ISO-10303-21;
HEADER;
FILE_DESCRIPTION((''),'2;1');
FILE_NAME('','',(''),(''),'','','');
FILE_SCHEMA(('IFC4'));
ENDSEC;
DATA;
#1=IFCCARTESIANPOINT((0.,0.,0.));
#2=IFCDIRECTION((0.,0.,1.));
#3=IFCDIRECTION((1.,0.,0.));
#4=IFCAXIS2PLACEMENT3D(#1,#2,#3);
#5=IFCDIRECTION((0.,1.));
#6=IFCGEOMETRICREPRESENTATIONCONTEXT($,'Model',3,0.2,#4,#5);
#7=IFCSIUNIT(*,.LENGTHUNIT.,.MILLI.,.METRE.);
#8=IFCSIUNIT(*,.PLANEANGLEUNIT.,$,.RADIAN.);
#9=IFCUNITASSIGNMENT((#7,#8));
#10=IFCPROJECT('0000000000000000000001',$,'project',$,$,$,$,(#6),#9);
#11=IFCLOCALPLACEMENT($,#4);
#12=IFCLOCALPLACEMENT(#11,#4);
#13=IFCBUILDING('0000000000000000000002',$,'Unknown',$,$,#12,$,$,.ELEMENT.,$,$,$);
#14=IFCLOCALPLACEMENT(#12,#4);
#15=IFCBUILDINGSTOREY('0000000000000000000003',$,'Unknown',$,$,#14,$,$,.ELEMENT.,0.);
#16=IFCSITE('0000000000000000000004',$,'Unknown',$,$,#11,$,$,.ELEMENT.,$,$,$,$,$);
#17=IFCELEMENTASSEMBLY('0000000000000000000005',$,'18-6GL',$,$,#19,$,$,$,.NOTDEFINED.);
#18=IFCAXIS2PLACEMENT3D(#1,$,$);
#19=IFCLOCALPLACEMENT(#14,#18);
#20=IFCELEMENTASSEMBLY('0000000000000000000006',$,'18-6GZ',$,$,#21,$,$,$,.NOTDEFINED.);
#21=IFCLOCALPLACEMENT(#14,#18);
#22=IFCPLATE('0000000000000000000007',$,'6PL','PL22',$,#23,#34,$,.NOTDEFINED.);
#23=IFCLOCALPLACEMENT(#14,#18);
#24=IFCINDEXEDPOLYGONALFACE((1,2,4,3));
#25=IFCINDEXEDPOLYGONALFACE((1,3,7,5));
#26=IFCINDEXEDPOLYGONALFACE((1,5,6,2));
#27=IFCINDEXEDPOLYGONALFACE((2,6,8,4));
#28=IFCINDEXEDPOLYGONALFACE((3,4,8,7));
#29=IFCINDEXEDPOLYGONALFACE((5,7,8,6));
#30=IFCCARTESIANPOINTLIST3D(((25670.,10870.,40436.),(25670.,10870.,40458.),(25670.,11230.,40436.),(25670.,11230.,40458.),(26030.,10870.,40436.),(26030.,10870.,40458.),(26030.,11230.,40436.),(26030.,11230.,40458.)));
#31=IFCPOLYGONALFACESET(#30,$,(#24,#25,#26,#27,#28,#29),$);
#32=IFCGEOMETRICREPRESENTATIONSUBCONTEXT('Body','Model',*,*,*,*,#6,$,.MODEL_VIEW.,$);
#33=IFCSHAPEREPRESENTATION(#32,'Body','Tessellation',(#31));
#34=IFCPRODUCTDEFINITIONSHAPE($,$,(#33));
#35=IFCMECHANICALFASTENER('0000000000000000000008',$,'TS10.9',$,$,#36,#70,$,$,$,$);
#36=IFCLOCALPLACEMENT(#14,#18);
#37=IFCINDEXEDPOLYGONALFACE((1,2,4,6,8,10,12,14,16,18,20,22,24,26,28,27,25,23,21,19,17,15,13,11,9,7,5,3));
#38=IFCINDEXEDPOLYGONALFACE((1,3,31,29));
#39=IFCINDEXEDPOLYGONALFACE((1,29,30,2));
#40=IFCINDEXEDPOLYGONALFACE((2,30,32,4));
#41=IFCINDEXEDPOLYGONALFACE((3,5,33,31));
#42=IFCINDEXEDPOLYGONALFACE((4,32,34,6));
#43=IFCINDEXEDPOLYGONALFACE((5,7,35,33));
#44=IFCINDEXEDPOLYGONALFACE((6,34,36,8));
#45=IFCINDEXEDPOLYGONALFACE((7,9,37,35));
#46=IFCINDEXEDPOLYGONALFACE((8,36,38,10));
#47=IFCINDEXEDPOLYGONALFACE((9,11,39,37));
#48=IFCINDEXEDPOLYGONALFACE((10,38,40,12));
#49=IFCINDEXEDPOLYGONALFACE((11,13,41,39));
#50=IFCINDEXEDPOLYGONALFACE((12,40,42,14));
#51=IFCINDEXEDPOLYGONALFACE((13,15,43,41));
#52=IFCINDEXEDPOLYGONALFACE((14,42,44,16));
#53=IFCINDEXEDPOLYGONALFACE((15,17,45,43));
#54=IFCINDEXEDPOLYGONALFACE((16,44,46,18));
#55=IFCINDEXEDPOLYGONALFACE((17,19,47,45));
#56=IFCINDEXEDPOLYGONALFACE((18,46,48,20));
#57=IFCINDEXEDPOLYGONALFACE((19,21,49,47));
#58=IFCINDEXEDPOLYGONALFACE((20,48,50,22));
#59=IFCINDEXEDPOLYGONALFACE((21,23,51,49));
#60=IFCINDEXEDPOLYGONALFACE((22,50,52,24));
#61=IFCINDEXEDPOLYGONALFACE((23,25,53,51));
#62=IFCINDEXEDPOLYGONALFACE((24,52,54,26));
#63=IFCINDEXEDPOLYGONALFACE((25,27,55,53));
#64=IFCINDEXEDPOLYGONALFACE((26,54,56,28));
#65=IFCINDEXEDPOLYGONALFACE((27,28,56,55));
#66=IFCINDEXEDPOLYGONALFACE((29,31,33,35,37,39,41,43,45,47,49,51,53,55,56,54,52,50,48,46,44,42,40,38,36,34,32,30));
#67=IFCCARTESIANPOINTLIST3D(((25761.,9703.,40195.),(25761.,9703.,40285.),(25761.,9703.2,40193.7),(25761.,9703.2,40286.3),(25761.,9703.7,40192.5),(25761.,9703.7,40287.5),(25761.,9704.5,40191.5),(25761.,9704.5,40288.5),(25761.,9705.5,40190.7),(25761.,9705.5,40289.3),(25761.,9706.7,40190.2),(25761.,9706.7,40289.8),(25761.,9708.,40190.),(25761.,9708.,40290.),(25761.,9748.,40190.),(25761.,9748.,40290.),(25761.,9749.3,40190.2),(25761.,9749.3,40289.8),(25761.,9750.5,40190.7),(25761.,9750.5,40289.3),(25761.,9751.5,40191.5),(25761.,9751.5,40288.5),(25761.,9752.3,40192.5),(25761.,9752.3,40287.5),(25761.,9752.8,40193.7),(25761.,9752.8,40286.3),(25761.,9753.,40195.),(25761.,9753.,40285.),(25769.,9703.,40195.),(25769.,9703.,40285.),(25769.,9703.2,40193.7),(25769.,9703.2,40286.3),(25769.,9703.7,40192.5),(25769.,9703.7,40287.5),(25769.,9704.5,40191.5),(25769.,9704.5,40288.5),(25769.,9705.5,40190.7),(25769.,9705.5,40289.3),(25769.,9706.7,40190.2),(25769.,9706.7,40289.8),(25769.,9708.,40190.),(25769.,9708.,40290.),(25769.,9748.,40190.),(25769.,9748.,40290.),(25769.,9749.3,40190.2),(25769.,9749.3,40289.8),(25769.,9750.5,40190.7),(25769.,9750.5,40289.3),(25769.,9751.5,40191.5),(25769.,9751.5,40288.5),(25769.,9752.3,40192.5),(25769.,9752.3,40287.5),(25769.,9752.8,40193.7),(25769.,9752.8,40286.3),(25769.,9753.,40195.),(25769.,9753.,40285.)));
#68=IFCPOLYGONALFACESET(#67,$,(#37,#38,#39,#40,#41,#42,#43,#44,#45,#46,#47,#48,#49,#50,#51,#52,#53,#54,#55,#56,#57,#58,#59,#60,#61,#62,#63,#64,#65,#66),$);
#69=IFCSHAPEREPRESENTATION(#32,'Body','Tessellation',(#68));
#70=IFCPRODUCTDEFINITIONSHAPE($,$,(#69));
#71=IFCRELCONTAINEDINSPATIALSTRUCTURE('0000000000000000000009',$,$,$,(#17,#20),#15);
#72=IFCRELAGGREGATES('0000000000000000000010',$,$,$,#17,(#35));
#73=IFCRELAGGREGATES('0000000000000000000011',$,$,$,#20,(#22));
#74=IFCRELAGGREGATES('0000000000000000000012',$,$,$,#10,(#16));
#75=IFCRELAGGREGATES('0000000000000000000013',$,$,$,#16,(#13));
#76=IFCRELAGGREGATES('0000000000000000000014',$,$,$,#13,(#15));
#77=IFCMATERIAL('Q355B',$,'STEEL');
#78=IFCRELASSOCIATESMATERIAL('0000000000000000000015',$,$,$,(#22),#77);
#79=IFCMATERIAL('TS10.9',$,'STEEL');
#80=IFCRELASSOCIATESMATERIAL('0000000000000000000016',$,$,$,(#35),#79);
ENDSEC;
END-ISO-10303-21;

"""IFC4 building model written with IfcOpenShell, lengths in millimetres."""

from ifc_helpers import new_model, si_unit, direction, frame, origin_with_axes, place, context, subcontext, project, spatial, line, arc, indexed_curve, outline, extrude, source, transform, mapped, material, element, aggregate, save


model = new_model("IFC4")

# Units and contexts
model_context = context("Model", 3, precision=0.2, world=origin_with_axes(), true_north=direction((0.0, 1.0)))
body_context = subcontext(model_context, "Body", "Model", "MODEL_VIEW")
ifc_project = project(units=[si_unit("LENGTHUNIT", "METRE", prefix="MILLI"), si_unit("PLANEANGLEUNIT", "RADIAN")], contexts=[model_context])

# Site, building, storey
site_placement = place(None, origin_with_axes())
site = spatial("IfcSite", under=ifc_project, at=site_placement, Name="Unknown", CompositionType="ELEMENT")
building_placement = place(site_placement, origin_with_axes())
building = spatial("IfcBuilding", under=site, at=building_placement, Name="Unknown", CompositionType="ELEMENT")
storey_placement = place(building_placement, origin_with_axes())
storey = spatial("IfcBuildingStorey", under=building, at=storey_placement, Name="Unknown", CompositionType="ELEMENT", Elevation=0.0)

# Element assembly
assembly_1_placement = place(storey_placement, frame((25765.0, 10900.0, 40240.0), z_axis=(-1.0, 0.0, 0.0), x_axis=(0.0, -1.0, 0.0)))
assembly_1 = element("IfcElementAssembly", 1, at=assembly_1_placement, inside=storey, Name="18-6GL", PredefinedType="NOTDEFINED")
ifc_material_1 = material(Name="Q355B", Category="STEEL")

# Element assembly
assembly_2_placement = place(storey_placement, frame((25850.0, 11050.0, 35950.0), z_axis=(-1.0, 0.0, 0.0), x_axis=(0.0, 0.0, 1.0)))
assembly_2 = element("IfcElementAssembly", 2, at=assembly_2_placement, inside=storey, Name="18-6GZ", PredefinedType="NOTDEFINED")

# Plate
plate_1_placement = place(assembly_2_placement, frame((4497.0, -180.0, 180.0), z_axis=(1.0, 0.0, 0.0), x_axis=(0.0, 0.0, -1.0)))
plate_1 = element("IfcPlate", 3, at=plate_1_placement, material=ifc_material_1, Name="6PL", Description="PL22", PredefinedType="NOTDEFINED", context=body_context, shape_type="SolidModel", body=[
    extrude(outline(indexed_curve([(0.0, 0.0), (360.0, 0.0), (360.0, 360.0), (0.0, 360.0)], segments=[line(1, 2, 3, 4, 1)])), frame((0.0, 0.0, 11.0), z_axis=(0.0, 0.0, 1.0), x_axis=(1.0, 0.0, 0.0)), (0.0, 0.0, -1.0), 22.0),
])

# Mechanical fastener
ifc_material_2 = material(Name="TS10.9", Category="STEEL")
shared_shape_1 = source(origin_with_axes(), body_context, "Body", "SweptSolid", [
    extrude(outline(indexed_curve([(-45.0, 25.0), (45.0, 25.0), (45.0, 25.0), (48.5, 23.5), (50.0, 20.0), (50.0, -20.0), (48.5, -23.5), (45.0, -25.0), (-45.0, -25.0), (-45.5, -25.0), (-50.0, -20.0), (-50.0, 20.0), (-48.5, 23.5)], segments=[line(1, 2, 3), arc(3, 4, 5), line(5, 6), arc(6, 7, 8), line(8, 9), arc(9, 10, 11), line(11, 12), arc(12, 13, 1)])), frame((0.0, 0.0, 4.0), z_axis=(0.0, 0.0, -1.0), x_axis=(0.0, 1.0, 0.0)), (0.0, 0.0, 1.0), 8.0),
])
mechanical_fastener_1_placement = place(assembly_1_placement, frame((1172.0, 0.0, 0.0), z_axis=(0.0, 0.0, 1.0), x_axis=(-1.0, 0.0, 0.0)))
mechanical_fastener_1 = element("IfcMechanicalFastener", 4, at=mechanical_fastener_1_placement, material=ifc_material_2, Name="TS10.9", context=body_context, shape_type="MappedRepresentation", body=[
    mapped(shared_shape_1, transform((0.0, 0.0, 0.0))),
])
aggregate(assembly_1, [mechanical_fastener_1])
aggregate(assembly_2, [plate_1])

save(model, "model.ifc")
